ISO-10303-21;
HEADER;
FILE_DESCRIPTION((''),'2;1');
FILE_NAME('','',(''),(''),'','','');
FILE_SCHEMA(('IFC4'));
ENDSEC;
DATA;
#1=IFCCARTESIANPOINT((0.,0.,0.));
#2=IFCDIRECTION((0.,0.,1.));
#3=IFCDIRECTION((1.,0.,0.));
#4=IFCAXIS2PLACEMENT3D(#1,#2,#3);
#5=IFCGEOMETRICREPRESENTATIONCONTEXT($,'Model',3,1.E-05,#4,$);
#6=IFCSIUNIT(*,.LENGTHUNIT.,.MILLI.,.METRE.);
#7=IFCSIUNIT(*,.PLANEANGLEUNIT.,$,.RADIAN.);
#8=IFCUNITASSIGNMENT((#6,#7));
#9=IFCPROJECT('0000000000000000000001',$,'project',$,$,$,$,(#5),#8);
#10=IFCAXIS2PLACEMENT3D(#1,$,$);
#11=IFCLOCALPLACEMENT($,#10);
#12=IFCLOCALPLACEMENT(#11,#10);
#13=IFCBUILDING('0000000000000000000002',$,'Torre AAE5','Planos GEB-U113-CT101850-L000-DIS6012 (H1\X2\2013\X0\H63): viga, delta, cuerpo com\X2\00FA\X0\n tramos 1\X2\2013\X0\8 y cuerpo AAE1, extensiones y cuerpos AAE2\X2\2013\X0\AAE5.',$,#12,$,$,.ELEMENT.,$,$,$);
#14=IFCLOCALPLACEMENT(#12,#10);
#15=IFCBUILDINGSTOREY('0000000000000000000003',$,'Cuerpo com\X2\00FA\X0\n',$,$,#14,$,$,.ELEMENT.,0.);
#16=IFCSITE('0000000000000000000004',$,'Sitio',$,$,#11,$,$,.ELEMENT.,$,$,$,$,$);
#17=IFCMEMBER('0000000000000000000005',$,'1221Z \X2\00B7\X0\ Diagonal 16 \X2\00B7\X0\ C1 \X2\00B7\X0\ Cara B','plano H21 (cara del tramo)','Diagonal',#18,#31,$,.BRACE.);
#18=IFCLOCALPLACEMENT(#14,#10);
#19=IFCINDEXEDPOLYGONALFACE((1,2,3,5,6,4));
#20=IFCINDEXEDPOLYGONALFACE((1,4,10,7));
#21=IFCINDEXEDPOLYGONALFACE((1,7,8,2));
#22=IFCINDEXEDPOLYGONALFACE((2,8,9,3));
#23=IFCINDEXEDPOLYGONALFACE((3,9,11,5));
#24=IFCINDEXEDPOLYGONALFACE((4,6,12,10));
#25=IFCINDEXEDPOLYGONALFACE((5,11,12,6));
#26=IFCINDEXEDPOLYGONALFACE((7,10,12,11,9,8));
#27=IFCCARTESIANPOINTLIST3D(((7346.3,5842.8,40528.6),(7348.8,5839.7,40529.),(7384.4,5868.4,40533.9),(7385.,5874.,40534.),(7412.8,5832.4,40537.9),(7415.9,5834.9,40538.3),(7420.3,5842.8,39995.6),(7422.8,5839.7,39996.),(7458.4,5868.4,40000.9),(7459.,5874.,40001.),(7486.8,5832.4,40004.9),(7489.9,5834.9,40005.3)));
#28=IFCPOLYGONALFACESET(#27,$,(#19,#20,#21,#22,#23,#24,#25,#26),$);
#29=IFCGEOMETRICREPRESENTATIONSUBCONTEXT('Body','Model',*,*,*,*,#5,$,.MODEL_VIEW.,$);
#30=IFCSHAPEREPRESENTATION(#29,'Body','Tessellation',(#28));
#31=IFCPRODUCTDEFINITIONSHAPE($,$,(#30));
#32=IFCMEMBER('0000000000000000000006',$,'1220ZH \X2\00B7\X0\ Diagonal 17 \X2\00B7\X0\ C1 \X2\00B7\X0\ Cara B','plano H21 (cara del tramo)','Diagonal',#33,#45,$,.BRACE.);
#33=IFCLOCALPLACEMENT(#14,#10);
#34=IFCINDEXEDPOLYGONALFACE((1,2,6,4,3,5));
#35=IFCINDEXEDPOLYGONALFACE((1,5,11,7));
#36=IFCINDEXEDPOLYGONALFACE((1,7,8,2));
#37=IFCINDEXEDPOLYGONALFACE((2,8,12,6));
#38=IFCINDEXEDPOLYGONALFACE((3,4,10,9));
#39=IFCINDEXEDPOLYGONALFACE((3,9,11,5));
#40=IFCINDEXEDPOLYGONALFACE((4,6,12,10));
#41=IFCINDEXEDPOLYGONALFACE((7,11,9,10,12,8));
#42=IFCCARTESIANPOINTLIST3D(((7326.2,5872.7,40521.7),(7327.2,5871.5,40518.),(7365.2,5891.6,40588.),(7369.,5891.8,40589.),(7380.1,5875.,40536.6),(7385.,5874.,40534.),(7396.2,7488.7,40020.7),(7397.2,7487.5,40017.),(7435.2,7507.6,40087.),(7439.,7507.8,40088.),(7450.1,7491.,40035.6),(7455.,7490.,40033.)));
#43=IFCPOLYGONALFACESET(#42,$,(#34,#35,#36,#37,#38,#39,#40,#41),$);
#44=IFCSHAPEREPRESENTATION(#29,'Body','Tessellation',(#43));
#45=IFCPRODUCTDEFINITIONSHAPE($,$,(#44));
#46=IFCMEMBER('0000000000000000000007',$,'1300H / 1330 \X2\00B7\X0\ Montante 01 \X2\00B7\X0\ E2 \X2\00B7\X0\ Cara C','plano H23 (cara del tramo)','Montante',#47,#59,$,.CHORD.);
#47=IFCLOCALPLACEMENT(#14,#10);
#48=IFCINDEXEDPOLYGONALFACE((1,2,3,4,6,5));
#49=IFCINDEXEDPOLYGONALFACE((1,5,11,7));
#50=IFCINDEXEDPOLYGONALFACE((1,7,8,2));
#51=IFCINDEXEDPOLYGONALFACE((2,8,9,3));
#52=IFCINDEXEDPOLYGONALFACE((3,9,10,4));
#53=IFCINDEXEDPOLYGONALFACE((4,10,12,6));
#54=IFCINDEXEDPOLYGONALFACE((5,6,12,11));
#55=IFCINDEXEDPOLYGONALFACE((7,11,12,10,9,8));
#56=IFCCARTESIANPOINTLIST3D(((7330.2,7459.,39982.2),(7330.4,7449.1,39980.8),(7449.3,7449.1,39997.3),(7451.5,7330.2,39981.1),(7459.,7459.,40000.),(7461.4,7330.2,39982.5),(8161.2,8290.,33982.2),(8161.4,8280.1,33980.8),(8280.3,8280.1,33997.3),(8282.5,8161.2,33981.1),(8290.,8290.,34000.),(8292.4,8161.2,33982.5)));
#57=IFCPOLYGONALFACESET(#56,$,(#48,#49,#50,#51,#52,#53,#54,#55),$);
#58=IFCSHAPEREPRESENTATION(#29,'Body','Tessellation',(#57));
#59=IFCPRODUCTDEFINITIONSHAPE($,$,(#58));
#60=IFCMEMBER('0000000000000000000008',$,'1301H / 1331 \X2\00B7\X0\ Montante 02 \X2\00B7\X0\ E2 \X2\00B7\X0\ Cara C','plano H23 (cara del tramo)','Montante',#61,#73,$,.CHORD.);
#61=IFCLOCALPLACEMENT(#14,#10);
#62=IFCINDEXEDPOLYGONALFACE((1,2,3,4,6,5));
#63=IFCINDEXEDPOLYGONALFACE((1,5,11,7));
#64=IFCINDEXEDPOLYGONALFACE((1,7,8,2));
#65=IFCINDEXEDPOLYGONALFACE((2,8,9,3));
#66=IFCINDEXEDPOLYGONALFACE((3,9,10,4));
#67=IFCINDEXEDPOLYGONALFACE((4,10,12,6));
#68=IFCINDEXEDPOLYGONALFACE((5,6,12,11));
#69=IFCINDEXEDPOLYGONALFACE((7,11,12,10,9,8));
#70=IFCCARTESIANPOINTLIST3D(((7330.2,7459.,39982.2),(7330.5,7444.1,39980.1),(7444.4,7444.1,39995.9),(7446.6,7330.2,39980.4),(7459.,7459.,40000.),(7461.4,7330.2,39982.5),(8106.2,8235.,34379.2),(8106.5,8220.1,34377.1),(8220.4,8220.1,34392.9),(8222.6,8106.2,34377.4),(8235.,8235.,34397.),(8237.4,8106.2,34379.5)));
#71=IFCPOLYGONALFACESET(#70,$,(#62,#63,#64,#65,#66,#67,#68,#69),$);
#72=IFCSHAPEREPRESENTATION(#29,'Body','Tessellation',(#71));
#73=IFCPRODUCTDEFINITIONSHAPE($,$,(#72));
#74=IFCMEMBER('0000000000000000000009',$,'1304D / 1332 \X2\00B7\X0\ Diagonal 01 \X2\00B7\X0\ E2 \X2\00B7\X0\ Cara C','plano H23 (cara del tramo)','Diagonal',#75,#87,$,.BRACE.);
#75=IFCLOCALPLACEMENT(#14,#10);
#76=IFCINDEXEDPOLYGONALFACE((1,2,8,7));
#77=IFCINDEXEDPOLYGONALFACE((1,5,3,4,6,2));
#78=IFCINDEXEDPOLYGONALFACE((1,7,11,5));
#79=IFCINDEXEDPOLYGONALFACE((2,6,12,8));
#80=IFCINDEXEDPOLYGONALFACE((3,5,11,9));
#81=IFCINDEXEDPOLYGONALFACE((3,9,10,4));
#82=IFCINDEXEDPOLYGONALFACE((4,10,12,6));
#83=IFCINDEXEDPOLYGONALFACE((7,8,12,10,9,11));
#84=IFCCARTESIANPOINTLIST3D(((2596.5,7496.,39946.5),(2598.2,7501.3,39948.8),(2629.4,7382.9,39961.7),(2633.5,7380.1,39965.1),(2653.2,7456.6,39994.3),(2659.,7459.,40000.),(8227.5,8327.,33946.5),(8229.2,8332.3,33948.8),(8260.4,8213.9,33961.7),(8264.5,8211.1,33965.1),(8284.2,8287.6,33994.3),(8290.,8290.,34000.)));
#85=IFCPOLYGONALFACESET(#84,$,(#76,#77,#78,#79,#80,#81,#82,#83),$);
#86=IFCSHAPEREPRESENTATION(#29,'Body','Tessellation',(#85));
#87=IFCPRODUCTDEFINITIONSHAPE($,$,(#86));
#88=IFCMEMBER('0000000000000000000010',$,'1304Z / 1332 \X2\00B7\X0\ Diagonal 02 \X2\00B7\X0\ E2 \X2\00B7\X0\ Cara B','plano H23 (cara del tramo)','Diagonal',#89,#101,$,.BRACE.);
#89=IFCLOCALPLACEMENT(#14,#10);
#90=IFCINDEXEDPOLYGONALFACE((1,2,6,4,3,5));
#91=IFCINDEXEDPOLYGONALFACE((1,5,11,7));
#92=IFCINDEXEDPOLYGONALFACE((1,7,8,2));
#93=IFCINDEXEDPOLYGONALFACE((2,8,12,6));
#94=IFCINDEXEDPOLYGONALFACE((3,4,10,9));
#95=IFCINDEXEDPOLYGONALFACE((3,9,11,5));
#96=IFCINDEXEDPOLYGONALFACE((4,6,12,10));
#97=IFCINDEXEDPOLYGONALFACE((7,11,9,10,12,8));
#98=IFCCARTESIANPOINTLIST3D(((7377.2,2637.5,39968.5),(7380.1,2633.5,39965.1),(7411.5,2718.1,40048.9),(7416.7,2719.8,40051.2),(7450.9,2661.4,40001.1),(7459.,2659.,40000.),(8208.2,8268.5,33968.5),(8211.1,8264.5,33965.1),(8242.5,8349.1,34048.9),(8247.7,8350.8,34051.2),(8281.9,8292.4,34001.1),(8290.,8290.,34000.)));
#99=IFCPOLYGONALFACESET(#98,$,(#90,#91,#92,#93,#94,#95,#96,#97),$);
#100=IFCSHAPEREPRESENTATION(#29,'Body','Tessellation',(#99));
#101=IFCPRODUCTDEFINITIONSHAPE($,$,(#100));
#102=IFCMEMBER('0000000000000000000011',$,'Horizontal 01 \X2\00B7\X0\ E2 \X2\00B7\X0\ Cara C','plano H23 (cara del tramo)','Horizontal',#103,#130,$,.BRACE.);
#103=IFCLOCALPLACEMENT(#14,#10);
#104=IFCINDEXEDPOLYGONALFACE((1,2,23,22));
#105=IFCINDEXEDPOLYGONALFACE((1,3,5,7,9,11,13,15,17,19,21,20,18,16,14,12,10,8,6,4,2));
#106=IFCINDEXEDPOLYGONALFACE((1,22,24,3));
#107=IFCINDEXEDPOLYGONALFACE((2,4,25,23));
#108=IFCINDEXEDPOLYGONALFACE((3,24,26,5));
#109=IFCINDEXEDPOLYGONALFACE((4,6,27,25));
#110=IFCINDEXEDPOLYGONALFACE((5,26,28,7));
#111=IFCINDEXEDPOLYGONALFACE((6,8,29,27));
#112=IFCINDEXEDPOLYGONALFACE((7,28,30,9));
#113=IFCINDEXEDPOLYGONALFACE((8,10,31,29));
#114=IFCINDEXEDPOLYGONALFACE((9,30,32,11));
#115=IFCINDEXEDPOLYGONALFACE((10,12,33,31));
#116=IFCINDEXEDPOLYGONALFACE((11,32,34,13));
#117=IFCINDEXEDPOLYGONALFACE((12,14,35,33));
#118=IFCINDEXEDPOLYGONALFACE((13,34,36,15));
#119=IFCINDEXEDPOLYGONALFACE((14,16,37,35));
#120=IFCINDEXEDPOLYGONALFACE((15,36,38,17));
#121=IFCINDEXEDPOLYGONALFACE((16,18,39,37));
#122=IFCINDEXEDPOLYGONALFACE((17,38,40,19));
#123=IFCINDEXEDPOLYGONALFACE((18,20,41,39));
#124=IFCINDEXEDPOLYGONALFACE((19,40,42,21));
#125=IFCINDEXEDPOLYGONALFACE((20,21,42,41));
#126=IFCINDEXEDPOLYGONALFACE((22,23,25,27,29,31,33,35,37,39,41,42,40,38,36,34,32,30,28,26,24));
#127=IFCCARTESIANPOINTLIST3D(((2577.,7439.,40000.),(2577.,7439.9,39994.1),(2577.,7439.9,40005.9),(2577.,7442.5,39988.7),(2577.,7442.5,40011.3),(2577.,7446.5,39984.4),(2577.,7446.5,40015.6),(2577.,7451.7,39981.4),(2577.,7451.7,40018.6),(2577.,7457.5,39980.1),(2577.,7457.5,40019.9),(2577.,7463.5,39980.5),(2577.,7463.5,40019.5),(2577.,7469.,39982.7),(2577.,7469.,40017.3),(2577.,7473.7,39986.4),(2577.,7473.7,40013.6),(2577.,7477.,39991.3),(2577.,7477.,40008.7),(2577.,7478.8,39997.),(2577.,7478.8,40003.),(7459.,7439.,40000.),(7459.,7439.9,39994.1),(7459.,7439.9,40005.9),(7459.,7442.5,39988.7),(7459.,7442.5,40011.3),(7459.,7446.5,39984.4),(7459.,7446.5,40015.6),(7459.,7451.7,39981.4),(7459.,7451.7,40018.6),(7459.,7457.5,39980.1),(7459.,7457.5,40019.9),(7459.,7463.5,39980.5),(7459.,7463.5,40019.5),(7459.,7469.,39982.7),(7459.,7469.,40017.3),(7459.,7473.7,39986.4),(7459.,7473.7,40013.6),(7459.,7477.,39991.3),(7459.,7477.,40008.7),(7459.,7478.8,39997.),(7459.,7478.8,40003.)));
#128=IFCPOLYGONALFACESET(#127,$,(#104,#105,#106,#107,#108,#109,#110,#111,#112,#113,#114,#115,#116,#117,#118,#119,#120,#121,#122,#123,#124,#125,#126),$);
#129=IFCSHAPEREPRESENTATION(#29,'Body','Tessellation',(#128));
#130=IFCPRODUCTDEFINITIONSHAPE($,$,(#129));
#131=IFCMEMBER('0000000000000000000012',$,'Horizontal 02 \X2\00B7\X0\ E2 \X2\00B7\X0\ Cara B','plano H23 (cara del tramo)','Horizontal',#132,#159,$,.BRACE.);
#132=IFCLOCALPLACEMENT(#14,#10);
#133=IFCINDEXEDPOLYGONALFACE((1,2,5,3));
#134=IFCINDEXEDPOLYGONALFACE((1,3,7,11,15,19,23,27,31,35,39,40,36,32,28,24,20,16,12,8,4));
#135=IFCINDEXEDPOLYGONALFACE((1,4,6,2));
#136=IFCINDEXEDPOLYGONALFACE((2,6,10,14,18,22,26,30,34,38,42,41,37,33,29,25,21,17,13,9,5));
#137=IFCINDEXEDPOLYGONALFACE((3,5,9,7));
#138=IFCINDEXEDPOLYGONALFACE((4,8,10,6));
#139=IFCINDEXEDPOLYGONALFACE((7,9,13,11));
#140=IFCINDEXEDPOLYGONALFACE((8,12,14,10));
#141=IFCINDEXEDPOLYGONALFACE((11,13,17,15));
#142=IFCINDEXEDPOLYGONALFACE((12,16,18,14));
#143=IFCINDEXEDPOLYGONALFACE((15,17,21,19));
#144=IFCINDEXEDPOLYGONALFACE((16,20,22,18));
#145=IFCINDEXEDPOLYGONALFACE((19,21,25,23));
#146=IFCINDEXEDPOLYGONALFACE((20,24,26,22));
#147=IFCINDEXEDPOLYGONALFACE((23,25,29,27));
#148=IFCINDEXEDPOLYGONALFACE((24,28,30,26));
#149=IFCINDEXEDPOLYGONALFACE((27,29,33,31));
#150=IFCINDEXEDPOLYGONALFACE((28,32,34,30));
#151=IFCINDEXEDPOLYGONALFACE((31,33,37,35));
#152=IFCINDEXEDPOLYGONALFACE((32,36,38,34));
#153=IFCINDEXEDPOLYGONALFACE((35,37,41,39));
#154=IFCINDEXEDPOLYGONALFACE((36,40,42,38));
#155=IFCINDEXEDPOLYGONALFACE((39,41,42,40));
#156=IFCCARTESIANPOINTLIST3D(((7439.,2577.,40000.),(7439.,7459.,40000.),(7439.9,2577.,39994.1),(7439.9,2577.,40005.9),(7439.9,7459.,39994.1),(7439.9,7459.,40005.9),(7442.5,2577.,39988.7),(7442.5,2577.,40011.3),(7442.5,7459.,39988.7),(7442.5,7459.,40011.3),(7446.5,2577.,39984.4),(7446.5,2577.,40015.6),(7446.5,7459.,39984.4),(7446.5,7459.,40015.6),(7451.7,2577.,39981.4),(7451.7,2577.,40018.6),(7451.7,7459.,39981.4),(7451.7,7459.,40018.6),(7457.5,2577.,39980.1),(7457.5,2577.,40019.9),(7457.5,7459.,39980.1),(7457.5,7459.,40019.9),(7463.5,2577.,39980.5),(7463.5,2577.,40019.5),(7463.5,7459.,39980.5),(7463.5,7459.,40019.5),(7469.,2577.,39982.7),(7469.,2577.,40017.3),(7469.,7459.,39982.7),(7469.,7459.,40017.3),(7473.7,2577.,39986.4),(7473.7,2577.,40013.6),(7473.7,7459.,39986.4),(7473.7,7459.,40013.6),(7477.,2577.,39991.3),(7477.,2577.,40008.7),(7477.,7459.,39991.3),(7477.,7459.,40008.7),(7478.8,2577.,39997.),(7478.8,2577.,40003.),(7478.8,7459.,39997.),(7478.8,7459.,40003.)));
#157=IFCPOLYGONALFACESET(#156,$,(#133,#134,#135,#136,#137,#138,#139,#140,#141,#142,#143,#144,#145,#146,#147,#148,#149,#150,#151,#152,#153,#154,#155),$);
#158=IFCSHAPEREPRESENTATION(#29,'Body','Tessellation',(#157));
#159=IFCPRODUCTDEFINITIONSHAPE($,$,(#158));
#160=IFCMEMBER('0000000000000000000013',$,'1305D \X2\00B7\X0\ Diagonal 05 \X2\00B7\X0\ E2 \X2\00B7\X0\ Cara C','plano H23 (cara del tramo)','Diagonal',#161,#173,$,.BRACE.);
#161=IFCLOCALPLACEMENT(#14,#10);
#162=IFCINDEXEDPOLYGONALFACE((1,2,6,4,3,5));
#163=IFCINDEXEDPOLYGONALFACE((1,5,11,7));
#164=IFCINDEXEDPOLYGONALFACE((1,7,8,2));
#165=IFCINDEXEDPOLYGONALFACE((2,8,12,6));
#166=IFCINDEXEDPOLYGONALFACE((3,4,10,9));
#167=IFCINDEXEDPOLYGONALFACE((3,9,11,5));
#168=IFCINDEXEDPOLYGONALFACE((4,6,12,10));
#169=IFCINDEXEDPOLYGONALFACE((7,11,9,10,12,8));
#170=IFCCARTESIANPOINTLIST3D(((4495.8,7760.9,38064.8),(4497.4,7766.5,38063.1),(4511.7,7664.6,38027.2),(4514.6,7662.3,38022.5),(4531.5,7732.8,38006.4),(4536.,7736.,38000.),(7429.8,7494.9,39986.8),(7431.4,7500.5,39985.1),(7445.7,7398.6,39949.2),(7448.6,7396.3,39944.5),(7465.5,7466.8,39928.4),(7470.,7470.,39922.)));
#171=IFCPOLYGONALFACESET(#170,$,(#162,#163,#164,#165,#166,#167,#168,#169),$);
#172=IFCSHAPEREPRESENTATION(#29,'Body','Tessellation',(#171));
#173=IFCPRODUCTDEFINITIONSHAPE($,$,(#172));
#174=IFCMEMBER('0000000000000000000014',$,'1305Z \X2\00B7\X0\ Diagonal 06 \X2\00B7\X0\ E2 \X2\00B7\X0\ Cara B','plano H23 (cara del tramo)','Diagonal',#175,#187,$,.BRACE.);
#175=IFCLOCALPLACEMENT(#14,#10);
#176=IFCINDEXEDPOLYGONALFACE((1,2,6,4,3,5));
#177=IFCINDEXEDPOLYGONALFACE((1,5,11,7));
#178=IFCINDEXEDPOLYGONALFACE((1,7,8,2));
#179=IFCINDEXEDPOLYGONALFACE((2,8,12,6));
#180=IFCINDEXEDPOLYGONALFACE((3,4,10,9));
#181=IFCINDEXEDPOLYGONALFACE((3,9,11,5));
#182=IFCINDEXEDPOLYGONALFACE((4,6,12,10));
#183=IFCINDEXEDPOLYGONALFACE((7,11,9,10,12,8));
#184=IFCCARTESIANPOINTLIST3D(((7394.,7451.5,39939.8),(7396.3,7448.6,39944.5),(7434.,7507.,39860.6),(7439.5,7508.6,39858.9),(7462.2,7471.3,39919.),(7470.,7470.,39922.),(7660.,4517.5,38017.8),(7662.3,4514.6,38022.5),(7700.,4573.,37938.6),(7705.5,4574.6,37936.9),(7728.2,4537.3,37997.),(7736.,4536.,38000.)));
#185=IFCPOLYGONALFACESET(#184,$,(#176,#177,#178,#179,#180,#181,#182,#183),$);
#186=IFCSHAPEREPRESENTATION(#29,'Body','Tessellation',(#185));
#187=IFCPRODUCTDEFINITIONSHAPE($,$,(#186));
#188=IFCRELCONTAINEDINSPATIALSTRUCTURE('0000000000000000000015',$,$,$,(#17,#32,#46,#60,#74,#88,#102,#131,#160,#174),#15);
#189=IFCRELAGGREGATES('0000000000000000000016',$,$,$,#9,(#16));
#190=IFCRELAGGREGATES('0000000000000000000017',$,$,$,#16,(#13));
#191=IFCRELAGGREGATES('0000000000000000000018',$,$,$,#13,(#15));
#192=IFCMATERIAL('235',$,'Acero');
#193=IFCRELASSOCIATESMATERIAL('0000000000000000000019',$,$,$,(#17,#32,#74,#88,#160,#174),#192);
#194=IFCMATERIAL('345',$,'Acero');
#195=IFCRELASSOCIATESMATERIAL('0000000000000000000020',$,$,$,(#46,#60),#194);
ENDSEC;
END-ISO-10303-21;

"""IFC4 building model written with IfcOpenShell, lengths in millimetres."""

from ifc_helpers import new_model, si_unit, frame, frame_2d, origin, origin_with_axes, place, context, subcontext, project, spatial, circle, l_section, extrude, material, element, save


model = new_model("IFC4")

# Units and contexts
model_context = context("Model", 3, precision=1e-05, world=origin_with_axes())
body_context = subcontext(model_context, "Body", "Model", "MODEL_VIEW")
ifc_project = project(units=[si_unit("LENGTHUNIT", "METRE", prefix="MILLI"), si_unit("PLANEANGLEUNIT", "RADIAN")], contexts=[model_context])

# Site, building, storey
site_placement = place(None, origin())
site = spatial("IfcSite", under=ifc_project, at=site_placement, Name="Sitio", CompositionType="ELEMENT")
building_placement = place(site_placement, origin())
building = spatial("IfcBuilding", under=site, at=building_placement, Name="Torre AAE5", Description="Planos GEB-U113-CT101850-L000-DIS6012 (H1–H63): viga, delta, cuerpo común tramos 1–8 y cuerpo AAE1, extensiones y cuerpos AAE2–AAE5.", CompositionType="ELEMENT")
storey_placement = place(building_placement, origin())
storey = spatial("IfcBuildingStorey", under=building, at=storey_placement, Name="Cuerpo común", CompositionType="ELEMENT", Elevation=0.0)

# Members
ifc_material_1 = material(Name="345", Category="Acero")
ifc_material_2 = material(Name="235", Category="Acero")
for number, where, z_axis, x_axis, name in (
    (1, (7459.0, 5874.0, 40001.0), (-0.137518, 0.0, 0.990499), (-0.773819, -0.624229, -0.107435), "1221Z · Diagonal 16 · C1 · Cara B"),
):
    element("IfcMember", number, at=place(storey_placement, frame(where, z_axis=z_axis, x_axis=x_axis)), inside=storey, material=ifc_material_2, Name=name, Description="plano H21 (cara del tramo)", ObjectType="Diagonal", PredefinedType="BRACE", context=body_context, shape_type="SweptSolid", body=[
        extrude(l_section(Depth=50.0, Width=50.0, Thickness=4.0, at=frame_2d((25.0, 25.0))), None, (0.0, 0.0, 1.0), 538.1),
    ])
member_1_placement = place(storey_placement, frame((7385.0, 5874.0, 40534.0), z_axis=(0.041339, 0.954334, -0.295867), x_axis=(-0.96295, -0.040927, -0.266555)))
element("IfcMember", 2, at=member_1_placement, inside=storey, material=ifc_material_2, Name="1220ZH · Diagonal 17 · C1 · Cara B", Description="plano H21 (cara del tramo)", ObjectType="Diagonal", PredefinedType="BRACE", context=body_context, shape_type="SweptSolid", body=[
    extrude(l_section(Depth=60.0, Width=60.0, Thickness=4.0, at=frame_2d((30.0, 30.0))), None, (0.0, 0.0, 1.0), 1693.3),
])
member_2_placement = place(storey_placement, frame((7459.0, 7459.0, 40000.0), z_axis=(0.135917, 0.135917, -0.981353), x_axis=(0.018647, -0.99072, -0.134632)))
element("IfcMember", 3, at=member_2_placement, inside=storey, material=ifc_material_1, Name="1300H / 1330 · Montante 01 · E2 · Cara C", Description="plano H23 (cara del tramo)", ObjectType="Montante", PredefinedType="CHORD", context=body_context, shape_type="SweptSolid", body=[
    extrude(l_section(Depth=130.0, Width=130.0, Thickness=10.0, at=frame_2d((65.0, 65.0))), None, (0.0, 0.0, 1.0), 6114.0),
])
member_3_placement = place(storey_placement, frame((7459.0, 7459.0, 40000.0), z_axis=(0.135915, 0.135915, -0.981353), x_axis=(0.018646, -0.990721, -0.13463)))
element("IfcMember", 4, at=member_3_placement, inside=storey, material=ifc_material_1, Name="1301H / 1331 · Montante 02 · E2 · Cara C", Description="plano H23 (cara del tramo)", ObjectType="Montante", PredefinedType="CHORD", context=body_context, shape_type="SweptSolid", body=[
    extrude(l_section(Depth=130.0, Width=130.0, Thickness=15.0, at=frame_2d((65.0, 65.0))), None, (0.0, 0.0, 1.0), 5709.5),
])
for number, where, z_axis, x_axis, name in (
    (5, (2659.0, 7459.0, 40000.0), (0.680866, 0.100479, -0.725483), (-0.283466, -0.877196, -0.387524), "1304D / 1332 · Diagonal 01 · E2 · Cara C"),
    (6, (7459.0, 2659.0, 40000.0), (0.100479, 0.680866, -0.725483), (-0.877196, -0.283466, -0.387524), "1304Z / 1332 · Diagonal 02 · E2 · Cara B"),
):
    element("IfcMember", number, at=place(storey_placement, frame(where, z_axis=z_axis, x_axis=x_axis)), inside=storey, material=ifc_material_2, Name=name, Description="plano H23 (cara del tramo)", ObjectType="Diagonal", PredefinedType="BRACE", context=body_context, shape_type="SweptSolid", body=[
        extrude(l_section(Depth=90.0, Width=90.0, Thickness=6.0, at=frame_2d((45.0, 45.0))), None, (0.0, 0.0, 1.0), 8270.4),
    ])
for number, where, z_axis, x_axis, name in (
    (7, (7459.0, 7459.0, 40000.0), (-1.0, 0.0, 0.0), (0.0, -1.0, 0.0), "Horizontal 01 · E2 · Cara C"),
    (8, (7459.0, 7459.0, 40000.0), (0.0, -1.0, 0.0), (-1.0, 0.0, 0.0), "Horizontal 02 · E2 · Cara B"),
):
    element("IfcMember", number, at=place(storey_placement, frame(where, z_axis=z_axis, x_axis=x_axis)), inside=storey, Name=name, Description="plano H23 (cara del tramo)", ObjectType="Horizontal", PredefinedType="BRACE", context=body_context, shape_type="SweptSolid", body=[
        extrude(circle(Radius=20.0), None, (0.0, 0.0, 1.0), 4882.0),
    ])
for number, where, z_axis, x_axis, name in (
    (9, (7470.0, 7470.0, 39922.0), (-0.834102, 0.075621, -0.546402), (-0.267724, -0.921564, 0.281148), "1305D · Diagonal 05 · E2 · Cara C"),
    (10, (7470.0, 7470.0, 39922.0), (0.075621, -0.834102, -0.546402), (-0.921564, -0.267724, 0.281148), "1305Z · Diagonal 06 · E2 · Cara B"),
):
    element("IfcMember", number, at=place(storey_placement, frame(where, z_axis=z_axis, x_axis=x_axis)), inside=storey, material=ifc_material_2, Name=name, Description="plano H23 (cara del tramo)", ObjectType="Diagonal", PredefinedType="BRACE", context=body_context, shape_type="SweptSolid", body=[
        extrude(l_section(Depth=80.0, Width=80.0, Thickness=6.0, at=frame_2d((40.0, 40.0))), None, (0.0, 0.0, 1.0), 3517.6),
    ])

save(model, "model.ifc")
